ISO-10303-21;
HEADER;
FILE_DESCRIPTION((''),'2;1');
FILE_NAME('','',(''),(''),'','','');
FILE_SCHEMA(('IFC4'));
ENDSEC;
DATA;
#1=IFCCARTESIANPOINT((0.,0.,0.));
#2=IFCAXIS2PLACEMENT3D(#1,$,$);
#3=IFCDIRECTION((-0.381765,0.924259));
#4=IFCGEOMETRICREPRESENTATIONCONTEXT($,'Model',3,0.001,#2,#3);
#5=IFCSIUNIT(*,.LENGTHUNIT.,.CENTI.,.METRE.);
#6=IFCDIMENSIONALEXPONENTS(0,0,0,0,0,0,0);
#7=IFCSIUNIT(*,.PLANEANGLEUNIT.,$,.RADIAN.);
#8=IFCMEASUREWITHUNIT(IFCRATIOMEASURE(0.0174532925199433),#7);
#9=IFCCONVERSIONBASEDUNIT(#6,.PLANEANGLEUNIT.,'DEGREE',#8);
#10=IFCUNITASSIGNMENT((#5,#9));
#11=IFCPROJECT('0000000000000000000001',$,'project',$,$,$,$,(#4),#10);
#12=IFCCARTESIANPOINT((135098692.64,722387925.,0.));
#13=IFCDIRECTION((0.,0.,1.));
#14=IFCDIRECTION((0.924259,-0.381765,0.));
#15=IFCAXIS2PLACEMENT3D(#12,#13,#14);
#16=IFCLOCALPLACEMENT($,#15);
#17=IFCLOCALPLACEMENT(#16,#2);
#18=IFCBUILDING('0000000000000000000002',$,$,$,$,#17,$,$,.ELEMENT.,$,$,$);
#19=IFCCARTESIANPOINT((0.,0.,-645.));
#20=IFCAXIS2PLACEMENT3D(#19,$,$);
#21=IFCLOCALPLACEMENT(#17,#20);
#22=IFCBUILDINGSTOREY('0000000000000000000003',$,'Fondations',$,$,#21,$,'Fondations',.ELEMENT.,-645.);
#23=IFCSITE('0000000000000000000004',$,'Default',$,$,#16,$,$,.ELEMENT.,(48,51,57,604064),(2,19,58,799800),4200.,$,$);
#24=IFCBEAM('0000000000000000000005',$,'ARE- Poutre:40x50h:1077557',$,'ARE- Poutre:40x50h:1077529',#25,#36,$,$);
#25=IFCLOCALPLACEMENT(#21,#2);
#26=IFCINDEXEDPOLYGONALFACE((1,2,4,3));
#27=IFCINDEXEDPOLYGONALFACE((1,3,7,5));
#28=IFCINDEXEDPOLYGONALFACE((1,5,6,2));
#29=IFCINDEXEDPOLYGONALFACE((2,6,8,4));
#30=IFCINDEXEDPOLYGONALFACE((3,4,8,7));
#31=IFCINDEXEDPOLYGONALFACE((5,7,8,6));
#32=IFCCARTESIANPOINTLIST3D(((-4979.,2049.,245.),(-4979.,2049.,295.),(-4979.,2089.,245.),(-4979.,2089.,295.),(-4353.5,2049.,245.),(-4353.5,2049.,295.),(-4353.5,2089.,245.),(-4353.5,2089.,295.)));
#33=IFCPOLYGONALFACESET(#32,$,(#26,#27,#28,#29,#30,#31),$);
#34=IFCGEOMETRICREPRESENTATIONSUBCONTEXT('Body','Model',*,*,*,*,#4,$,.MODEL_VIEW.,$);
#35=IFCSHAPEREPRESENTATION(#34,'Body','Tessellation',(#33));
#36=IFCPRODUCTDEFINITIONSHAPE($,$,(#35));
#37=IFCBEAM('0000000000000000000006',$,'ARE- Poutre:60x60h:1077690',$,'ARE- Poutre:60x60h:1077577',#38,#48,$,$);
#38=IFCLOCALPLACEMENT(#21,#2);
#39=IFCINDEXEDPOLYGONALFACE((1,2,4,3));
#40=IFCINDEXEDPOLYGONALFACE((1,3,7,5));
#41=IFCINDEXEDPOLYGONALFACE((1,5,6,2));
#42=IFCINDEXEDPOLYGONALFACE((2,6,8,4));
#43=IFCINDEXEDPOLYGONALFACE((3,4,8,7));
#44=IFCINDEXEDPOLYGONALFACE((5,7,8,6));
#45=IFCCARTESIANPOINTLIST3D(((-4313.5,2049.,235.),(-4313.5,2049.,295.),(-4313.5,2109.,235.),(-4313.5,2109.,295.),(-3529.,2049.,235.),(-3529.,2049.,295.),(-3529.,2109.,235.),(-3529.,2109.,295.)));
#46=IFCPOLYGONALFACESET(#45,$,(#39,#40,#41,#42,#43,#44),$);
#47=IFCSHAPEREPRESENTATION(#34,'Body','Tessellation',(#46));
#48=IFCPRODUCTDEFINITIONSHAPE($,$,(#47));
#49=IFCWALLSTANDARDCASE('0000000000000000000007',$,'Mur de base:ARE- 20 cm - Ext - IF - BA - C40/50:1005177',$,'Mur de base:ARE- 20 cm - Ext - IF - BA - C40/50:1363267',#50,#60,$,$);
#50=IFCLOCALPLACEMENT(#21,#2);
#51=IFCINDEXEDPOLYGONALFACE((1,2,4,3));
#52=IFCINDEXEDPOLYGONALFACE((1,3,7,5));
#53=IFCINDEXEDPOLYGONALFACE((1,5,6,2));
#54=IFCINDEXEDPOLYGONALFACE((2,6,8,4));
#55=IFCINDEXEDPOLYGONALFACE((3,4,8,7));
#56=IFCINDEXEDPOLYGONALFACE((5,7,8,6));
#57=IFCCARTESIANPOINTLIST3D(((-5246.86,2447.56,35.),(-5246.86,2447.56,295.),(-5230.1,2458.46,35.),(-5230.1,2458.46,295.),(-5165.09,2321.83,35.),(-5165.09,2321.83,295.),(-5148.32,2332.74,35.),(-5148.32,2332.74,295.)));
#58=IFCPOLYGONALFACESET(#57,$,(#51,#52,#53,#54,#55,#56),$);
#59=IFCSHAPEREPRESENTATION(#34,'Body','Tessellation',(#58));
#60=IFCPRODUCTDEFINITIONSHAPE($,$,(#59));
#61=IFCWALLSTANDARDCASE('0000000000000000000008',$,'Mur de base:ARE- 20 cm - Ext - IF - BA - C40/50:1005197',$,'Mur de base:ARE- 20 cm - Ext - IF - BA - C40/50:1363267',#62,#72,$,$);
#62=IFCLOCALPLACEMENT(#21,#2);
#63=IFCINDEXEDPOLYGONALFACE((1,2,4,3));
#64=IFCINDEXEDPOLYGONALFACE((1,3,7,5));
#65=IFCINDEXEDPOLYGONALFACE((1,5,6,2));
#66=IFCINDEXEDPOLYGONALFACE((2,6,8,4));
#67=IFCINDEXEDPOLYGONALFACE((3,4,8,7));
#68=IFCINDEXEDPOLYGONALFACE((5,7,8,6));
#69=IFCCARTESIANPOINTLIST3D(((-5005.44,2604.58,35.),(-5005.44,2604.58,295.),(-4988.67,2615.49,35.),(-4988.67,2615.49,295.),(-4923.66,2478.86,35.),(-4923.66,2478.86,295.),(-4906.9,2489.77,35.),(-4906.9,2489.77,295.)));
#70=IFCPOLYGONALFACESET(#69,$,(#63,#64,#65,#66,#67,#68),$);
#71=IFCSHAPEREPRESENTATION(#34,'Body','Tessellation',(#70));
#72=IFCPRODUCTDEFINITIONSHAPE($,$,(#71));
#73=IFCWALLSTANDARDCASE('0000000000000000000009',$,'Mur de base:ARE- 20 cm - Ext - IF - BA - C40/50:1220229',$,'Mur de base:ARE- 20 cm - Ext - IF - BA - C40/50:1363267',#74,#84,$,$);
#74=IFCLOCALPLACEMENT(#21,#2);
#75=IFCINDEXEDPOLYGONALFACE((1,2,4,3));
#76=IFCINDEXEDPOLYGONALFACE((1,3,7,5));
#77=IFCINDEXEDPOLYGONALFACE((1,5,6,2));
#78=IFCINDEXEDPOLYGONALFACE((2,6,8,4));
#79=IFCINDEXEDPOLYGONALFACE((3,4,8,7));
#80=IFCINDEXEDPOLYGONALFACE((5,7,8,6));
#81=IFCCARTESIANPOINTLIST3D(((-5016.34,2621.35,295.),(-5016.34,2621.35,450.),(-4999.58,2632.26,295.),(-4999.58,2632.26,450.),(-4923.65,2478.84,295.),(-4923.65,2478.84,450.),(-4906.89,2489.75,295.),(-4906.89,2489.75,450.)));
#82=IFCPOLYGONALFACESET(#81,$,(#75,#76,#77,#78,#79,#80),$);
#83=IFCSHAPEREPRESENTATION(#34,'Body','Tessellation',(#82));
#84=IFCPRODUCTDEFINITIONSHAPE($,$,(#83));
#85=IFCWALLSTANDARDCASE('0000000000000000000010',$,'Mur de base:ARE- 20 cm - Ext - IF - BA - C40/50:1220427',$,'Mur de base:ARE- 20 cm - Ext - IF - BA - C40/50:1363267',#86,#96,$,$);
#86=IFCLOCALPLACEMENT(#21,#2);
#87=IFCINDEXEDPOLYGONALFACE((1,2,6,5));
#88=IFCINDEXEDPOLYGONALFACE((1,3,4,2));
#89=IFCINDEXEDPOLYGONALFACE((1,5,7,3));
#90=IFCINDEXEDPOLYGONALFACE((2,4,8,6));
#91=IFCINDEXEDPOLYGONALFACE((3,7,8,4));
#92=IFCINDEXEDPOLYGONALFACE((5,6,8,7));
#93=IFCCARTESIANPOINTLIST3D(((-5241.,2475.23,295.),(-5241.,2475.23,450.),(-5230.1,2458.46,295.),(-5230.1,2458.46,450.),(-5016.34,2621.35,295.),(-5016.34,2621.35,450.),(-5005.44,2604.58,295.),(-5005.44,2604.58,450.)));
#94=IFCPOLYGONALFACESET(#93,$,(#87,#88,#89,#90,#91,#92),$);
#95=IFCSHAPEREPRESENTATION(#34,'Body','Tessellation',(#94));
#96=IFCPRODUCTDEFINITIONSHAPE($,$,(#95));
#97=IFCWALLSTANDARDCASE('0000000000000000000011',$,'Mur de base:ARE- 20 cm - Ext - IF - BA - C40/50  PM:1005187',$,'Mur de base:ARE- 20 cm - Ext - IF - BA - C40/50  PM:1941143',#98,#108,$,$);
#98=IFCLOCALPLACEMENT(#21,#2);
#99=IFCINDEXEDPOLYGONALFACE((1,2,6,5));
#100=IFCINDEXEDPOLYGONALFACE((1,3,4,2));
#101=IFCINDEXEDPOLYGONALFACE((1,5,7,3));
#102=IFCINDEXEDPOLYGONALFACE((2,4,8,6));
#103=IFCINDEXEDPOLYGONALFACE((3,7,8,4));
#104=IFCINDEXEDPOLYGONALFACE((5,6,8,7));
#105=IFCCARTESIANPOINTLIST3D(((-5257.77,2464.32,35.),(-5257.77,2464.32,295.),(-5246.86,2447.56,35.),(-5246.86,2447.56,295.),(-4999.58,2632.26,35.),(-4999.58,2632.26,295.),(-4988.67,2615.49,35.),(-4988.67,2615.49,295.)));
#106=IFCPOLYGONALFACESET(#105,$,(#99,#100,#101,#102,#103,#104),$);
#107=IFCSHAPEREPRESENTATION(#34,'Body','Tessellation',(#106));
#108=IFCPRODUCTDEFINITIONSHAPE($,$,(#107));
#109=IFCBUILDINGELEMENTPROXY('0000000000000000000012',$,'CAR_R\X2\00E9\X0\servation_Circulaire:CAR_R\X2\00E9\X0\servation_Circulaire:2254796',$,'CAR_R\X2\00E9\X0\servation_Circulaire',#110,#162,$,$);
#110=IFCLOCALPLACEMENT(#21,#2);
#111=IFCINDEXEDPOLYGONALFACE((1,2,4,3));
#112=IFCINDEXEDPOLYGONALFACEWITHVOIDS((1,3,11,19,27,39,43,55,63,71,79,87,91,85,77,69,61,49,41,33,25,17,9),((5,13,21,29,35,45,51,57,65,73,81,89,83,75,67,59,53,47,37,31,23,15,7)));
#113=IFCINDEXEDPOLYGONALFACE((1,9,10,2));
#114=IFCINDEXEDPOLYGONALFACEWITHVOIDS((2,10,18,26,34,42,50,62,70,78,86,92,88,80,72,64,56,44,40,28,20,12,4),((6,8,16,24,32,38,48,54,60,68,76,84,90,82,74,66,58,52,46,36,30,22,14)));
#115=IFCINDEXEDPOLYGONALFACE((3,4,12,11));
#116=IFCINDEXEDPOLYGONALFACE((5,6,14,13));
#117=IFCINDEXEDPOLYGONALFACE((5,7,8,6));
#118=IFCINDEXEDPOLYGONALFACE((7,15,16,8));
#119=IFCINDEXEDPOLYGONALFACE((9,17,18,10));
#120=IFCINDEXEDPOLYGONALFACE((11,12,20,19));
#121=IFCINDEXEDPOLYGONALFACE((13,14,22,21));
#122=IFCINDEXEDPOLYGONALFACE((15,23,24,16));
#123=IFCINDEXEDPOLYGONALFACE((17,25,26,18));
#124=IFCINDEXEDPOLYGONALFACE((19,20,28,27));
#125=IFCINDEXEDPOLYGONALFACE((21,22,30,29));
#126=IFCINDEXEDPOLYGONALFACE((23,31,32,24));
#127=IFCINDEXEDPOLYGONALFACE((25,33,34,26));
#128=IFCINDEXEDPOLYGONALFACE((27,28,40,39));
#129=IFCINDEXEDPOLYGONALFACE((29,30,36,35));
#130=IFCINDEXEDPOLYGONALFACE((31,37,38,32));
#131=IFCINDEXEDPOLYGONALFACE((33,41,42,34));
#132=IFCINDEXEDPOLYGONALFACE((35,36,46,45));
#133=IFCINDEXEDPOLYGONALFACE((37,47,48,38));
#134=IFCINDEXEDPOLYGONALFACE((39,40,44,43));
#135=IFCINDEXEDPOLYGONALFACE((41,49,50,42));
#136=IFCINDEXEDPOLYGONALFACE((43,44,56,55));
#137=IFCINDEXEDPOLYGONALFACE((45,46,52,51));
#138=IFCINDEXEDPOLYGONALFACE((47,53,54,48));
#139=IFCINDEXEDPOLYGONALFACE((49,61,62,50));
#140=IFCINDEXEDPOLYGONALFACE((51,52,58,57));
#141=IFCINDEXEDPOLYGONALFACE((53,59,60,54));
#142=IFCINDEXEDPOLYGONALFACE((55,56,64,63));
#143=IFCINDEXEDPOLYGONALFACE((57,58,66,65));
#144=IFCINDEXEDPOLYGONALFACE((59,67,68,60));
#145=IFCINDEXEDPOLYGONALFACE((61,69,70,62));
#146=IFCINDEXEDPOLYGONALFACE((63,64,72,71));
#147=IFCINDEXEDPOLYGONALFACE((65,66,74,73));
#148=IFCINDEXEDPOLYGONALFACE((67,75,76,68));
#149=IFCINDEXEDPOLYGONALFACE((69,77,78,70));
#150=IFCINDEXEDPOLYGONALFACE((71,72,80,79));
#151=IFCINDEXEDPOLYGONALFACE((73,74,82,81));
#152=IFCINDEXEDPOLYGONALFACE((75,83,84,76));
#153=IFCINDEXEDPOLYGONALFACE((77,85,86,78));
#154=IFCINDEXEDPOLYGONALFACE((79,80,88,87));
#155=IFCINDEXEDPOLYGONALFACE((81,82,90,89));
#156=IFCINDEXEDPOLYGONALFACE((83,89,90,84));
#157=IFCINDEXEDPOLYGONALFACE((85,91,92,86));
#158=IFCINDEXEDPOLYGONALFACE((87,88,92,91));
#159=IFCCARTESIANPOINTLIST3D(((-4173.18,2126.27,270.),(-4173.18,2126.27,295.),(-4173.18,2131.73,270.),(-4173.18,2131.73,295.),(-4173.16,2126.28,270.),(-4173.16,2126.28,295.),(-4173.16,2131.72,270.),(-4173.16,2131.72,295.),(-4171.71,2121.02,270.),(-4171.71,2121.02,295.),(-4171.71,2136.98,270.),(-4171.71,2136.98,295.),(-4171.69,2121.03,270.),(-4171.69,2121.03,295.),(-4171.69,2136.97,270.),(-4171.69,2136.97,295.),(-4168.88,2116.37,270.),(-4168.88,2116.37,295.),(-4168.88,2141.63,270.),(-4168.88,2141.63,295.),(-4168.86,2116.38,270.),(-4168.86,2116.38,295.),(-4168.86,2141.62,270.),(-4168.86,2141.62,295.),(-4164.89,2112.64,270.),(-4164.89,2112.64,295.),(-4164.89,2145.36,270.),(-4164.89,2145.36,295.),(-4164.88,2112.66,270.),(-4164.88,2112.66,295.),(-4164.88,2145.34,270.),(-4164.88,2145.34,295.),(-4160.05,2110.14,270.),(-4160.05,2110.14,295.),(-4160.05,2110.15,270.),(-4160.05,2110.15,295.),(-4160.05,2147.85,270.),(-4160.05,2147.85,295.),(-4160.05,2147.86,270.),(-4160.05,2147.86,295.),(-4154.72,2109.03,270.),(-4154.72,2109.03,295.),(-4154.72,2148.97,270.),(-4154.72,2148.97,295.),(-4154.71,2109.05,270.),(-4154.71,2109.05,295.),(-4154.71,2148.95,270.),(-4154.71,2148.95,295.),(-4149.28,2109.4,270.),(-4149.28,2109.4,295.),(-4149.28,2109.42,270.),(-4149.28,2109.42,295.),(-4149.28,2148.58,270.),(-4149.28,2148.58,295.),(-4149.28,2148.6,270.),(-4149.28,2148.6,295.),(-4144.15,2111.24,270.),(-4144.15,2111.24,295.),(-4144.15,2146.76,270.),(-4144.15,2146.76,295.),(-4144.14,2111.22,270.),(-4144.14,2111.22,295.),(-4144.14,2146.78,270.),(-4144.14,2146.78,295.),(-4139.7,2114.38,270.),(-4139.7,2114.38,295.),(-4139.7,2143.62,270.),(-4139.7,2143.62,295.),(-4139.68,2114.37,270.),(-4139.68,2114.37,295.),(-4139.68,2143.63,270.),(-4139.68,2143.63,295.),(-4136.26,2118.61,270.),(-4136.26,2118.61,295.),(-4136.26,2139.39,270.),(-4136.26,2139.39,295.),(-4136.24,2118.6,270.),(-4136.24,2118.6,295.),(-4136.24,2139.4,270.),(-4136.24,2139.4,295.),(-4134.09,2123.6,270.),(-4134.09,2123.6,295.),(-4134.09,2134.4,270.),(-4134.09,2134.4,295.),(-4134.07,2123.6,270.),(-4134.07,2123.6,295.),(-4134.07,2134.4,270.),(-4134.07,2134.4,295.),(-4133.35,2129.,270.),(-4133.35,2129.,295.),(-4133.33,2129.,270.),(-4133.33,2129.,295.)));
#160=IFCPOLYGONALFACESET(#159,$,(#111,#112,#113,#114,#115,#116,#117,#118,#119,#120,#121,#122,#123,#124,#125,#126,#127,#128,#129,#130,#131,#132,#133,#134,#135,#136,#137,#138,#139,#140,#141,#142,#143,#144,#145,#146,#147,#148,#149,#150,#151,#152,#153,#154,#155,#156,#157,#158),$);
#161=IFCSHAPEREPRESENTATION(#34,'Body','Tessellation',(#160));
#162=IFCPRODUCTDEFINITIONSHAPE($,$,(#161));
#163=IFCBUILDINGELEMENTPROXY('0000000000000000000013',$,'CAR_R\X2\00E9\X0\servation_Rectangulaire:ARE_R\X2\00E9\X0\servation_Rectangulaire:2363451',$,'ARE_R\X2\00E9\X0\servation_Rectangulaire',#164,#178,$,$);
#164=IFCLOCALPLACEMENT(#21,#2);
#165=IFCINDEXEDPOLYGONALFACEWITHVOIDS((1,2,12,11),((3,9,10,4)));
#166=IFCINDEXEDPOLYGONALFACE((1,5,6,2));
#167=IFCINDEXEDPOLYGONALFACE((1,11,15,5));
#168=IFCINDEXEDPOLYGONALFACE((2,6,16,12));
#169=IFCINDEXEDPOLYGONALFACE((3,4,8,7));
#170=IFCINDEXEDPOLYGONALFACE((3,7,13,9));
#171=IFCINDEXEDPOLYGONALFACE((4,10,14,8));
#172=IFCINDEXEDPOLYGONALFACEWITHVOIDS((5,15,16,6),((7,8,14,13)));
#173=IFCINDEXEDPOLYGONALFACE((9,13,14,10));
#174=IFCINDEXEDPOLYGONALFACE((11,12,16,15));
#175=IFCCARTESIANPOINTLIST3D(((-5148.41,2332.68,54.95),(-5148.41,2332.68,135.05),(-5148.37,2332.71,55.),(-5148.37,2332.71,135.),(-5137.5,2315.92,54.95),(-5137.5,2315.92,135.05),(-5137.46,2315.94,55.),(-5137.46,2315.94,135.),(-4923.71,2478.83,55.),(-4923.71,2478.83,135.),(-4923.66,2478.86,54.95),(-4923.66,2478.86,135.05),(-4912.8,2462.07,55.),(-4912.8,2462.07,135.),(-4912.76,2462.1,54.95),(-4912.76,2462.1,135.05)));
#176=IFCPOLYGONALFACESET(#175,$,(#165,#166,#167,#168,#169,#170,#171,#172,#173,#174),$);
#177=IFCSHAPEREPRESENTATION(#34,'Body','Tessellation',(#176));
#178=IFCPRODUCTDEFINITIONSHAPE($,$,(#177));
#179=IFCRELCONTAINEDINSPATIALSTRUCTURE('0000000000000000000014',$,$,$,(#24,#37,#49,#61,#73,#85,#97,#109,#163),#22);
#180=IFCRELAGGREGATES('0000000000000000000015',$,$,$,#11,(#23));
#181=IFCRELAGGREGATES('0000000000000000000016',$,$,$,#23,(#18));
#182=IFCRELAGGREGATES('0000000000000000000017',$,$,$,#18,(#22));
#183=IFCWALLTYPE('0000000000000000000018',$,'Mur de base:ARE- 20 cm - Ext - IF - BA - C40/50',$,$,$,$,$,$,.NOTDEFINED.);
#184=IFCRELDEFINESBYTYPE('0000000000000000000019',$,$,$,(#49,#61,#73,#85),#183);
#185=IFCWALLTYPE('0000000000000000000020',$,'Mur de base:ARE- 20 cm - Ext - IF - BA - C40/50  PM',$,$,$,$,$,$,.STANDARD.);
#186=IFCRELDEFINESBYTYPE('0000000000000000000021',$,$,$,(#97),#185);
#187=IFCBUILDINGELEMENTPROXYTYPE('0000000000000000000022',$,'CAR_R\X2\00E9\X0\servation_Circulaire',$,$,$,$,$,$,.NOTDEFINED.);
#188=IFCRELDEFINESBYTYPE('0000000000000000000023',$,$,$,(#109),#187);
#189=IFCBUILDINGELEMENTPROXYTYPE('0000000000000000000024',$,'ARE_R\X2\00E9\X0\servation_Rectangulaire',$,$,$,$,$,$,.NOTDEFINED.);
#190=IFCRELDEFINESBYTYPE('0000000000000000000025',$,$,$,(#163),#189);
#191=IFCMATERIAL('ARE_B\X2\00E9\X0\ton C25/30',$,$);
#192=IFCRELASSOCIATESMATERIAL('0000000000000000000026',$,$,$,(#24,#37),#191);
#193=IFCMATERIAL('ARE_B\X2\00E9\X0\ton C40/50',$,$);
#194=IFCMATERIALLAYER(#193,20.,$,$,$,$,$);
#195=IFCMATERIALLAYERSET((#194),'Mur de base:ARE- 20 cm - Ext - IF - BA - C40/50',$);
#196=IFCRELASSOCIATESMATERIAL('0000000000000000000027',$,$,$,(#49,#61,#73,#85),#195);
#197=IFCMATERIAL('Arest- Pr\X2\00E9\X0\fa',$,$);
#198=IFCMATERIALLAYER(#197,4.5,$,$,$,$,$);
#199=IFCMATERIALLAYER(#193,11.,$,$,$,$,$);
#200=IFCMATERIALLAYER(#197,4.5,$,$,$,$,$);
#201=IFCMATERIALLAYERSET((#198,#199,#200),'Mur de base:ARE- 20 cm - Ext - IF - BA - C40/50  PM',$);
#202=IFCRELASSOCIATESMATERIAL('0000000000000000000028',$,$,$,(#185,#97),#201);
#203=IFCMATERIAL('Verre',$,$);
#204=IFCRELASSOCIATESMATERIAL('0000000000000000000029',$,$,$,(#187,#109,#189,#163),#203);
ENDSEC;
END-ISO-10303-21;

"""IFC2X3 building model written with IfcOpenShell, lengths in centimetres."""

from ifc_helpers import new_model, entity, si_unit, converted_unit, direction, frame, frame_2d, origin, place, context, subcontext, project, spatial, polyline, rectangle, hollow_circle, outline, extrude, source, transform, mapped, material, layer, layer_set, layer_usage, type_object, type_shapes, element, save


model = new_model("IFC2X3")

# Units and contexts
model_context = context("Model", 3, precision=0.001, world=origin(), true_north=direction((-0.381765, 0.924259)))
body_context = subcontext(model_context, "Body", "Model", "MODEL_VIEW")
ifc_project = project(units=[si_unit("LENGTHUNIT", "METRE", prefix="CENTI"), converted_unit("PLANEANGLEUNIT", "DEGREE", entity("IfcRatioMeasure", 0.0174532925199433), si_unit("PLANEANGLEUNIT", "RADIAN"), dimensions=[0, 0, 0, 0, 0, 0, 0])], contexts=[model_context])

# Site, building, storey
site_placement = place(None, frame((135098692.64, 722387925.0, 0.0), z_axis=(0.0, 0.0, 1.0), x_axis=(0.924259, -0.381765, 0.0)))
site = spatial("IfcSite", under=ifc_project, at=site_placement, Name="Default", CompositionType="ELEMENT", RefLatitude=(48, 51, 57, 604064), RefLongitude=(2, 19, 58, 799800), RefElevation=4200.0)
building_placement = place(site_placement, origin())
building = spatial("IfcBuilding", under=site, at=building_placement, CompositionType="ELEMENT")
storey_placement = place(building_placement, frame((0.0, 0.0, -645.0)))
storey = spatial("IfcBuildingStorey", under=building, at=storey_placement, Name="Fondations", LongName="Fondations", CompositionType="ELEMENT", Elevation=-645.0)

# Beams
ifc_material_1 = material(Name="ARE_Béton C25/30")
beam_1_placement = place(storey_placement, frame((-4979.0, 2069.0, 295.0)))
element("IfcBeam", 1, at=beam_1_placement, inside=storey, material=ifc_material_1, Name="ARE- Poutre:40x50h:1077557", ObjectType="ARE- Poutre:40x50h:1077529", context=body_context, shape_type="SweptSolid", body=[
    extrude(rectangle(XDim=50.0, YDim=40.0, at=frame_2d((0.0, 0.0), x_axis=(1.0, 0.0))), frame((0.0, 0.0, -25.0), z_axis=(1.0, 0.0, 0.0), x_axis=(0.0, 0.0, -1.0)), (0.0, 0.0, 1.0), 625.5),
])
beam_2_placement = place(storey_placement, frame((-4333.5, 2079.0, 295.0)))
element("IfcBeam", 2, at=beam_2_placement, inside=storey, material=ifc_material_1, Name="ARE- Poutre:60x60h:1077690", ObjectType="ARE- Poutre:60x60h:1077577", context=body_context, shape_type="SweptSolid", body=[
    extrude(rectangle(XDim=60.0, YDim=60.0, at=frame_2d((0.0, 0.0), x_axis=(1.0, 0.0))), frame((20.0, 0.0, -30.0), z_axis=(1.0, 0.0, 0.0), x_axis=(0.0, 0.0, -1.0)), (0.0, 0.0, 1.0), 784.5),
])

# Walls
ifc_material_2 = material(Name="ARE_Béton C40/50")
ifc_layer_1 = layer(ifc_material_2, 20.0)
ifc_layer_set_1 = layer_set([ifc_layer_1], Name="Mur de base:ARE- 20 cm - Ext - IF - BA - C40/50")
ifc_layer_usage_1 = layer_usage(ifc_layer_set_1, "AXIS2", "NEGATIVE", 10.0)
wall_type_1 = type_object("IfcWallType", Name="Mur de base:ARE- 20 cm - Ext - IF - BA - C40/50", PredefinedType="NOTDEFINED")
wall_1_placement = place(storey_placement, frame((-5238.48, 2453.01, 35.0), z_axis=(0.0, 0.0, 1.0), x_axis=(0.545236, -0.838282, 0.0)))
element("IfcWallStandardCase", 3, at=wall_1_placement, inside=storey, type_object=wall_type_1, material=ifc_layer_usage_1, Name="Mur de base:ARE- 20 cm - Ext - IF - BA - C40/50:1005177", ObjectType="Mur de base:ARE- 20 cm - Ext - IF - BA - C40/50:1363267", context=body_context, shape_type="SweptSolid", body=[
    extrude(rectangle(XDim=149.98, YDim=20.0, at=frame_2d((74.99, 0.0), x_axis=(-1.0, 0.0))), origin(), (0.0, 0.0, 1.0), 260.0),
])
ifc_layer_usage_2 = layer_usage(ifc_layer_set_1, "AXIS2", "NEGATIVE", 10.0)
wall_2_placement = place(storey_placement, frame((-4997.05, 2610.04, 35.0), z_axis=(0.0, 0.0, 1.0), x_axis=(0.545236, -0.838282, 0.0)))
element("IfcWallStandardCase", 4, at=wall_2_placement, inside=storey, type_object=wall_type_1, material=ifc_layer_usage_2, Name="Mur de base:ARE- 20 cm - Ext - IF - BA - C40/50:1005197", ObjectType="Mur de base:ARE- 20 cm - Ext - IF - BA - C40/50:1363267", context=body_context, shape_type="SweptSolid", body=[
    extrude(rectangle(XDim=149.98, YDim=20.0, at=frame_2d((74.99, 0.0), x_axis=(-1.0, 0.0))), origin(), (0.0, 0.0, 1.0), 260.0),
])
ifc_layer_usage_3 = layer_usage(ifc_layer_set_1, "AXIS2", "NEGATIVE", 10.0)
wall_3_placement = place(storey_placement, frame((-5007.96, 2626.8, 295.0), z_axis=(0.0, 0.0, 1.0), x_axis=(0.545236, -0.838282, 0.0)))
element("IfcWallStandardCase", 5, at=wall_3_placement, inside=storey, type_object=wall_type_1, material=ifc_layer_usage_3, Name="Mur de base:ARE- 20 cm - Ext - IF - BA - C40/50:1220229", ObjectType="Mur de base:ARE- 20 cm - Ext - IF - BA - C40/50:1363267", context=body_context, shape_type="SweptSolid", body=[
    extrude(rectangle(XDim=170.0, YDim=20.0, at=frame_2d((85.0, 0.0), x_axis=(-1.0, 0.0))), origin(), (0.0, 0.0, 1.0), 155.0),
])
ifc_layer_usage_4 = layer_usage(ifc_layer_set_1, "AXIS2", "NEGATIVE", 10.0)
wall_4_placement = place(storey_placement, frame((-5235.55, 2466.84, 295.0), z_axis=(0.0, 0.0, 1.0), x_axis=(0.838282, 0.545236, 0.0)))
element("IfcWallStandardCase", 6, at=wall_4_placement, inside=storey, type_object=wall_type_1, material=ifc_layer_usage_4, Name="Mur de base:ARE- 20 cm - Ext - IF - BA - C40/50:1220427", ObjectType="Mur de base:ARE- 20 cm - Ext - IF - BA - C40/50:1363267", context=body_context, shape_type="SweptSolid", body=[
    extrude(rectangle(XDim=268.0, YDim=20.0, at=frame_2d((134.0, 0.0), x_axis=(-1.0, 0.0))), origin(), (0.0, 0.0, 1.0), 155.0),
])
ifc_material_3 = material(Name="Arest- Préfa")
ifc_layer_2 = layer(ifc_material_3, 4.5)
ifc_layer_3 = layer(ifc_material_2, 11.0)
ifc_layer_4 = layer(ifc_material_3, 4.5)
ifc_layer_set_2 = layer_set([ifc_layer_2, ifc_layer_3, ifc_layer_4], Name="Mur de base:ARE- 20 cm - Ext - IF - BA - C40/50  PM")
ifc_layer_usage_5 = layer_usage(ifc_layer_set_2, "AXIS2", "NEGATIVE", 10.0)
wall_type_2 = type_object("IfcWallType", Name="Mur de base:ARE- 20 cm - Ext - IF - BA - C40/50  PM", PredefinedType="STANDARD", material=ifc_layer_set_2)
wall_5_placement = place(storey_placement, frame((-4994.12, 2623.87, 35.0), z_axis=(0.0, 0.0, 1.0), x_axis=(-0.838282, -0.545236, 0.0)))
element("IfcWallStandardCase", 7, at=wall_5_placement, inside=storey, type_object=wall_type_2, material=ifc_layer_usage_5, Name="Mur de base:ARE- 20 cm - Ext - IF - BA - C40/50  PM:1005187", ObjectType="Mur de base:ARE- 20 cm - Ext - IF - BA - C40/50  PM:1941143", context=body_context, shape_type="SweptSolid", body=[
    extrude(rectangle(XDim=308.0, YDim=20.0, at=frame_2d((154.0, 0.0), x_axis=(-1.0, 0.0))), origin(), (0.0, 0.0, 1.0), 260.0),
])

# Building element proxies
ifc_material_4 = material(Name="Verre")
building_element_proxy_type_1 = type_object("IfcBuildingElementProxyType", Name="CAR_Réservation_Circulaire", PredefinedType="NOTDEFINED", material=ifc_material_4)
shared_shape_1 = source(origin(), body_context, "Body", "SweptSolid", [
    extrude(hollow_circle(Radius=20.02, WallThickness=0.02, at=frame_2d((0.0, 0.0), x_axis=(1.0, 0.0))), frame((0.0, 0.0, -25.0)), (0.0, 0.0, 1.0), 25.0),
])
type_shapes(building_element_proxy_type_1, [shared_shape_1])
proxy_1_placement = place(storey_placement, frame((-4153.35, 2129.0, 295.0)))
element("IfcBuildingElementProxy", 8, at=proxy_1_placement, inside=storey, type_object=building_element_proxy_type_1, material=ifc_material_4, Name="CAR_Réservation_Circulaire:CAR_Réservation_Circulaire:2254796", ObjectType="CAR_Réservation_Circulaire", context=body_context, shape_type="MappedRepresentation", body=[
    mapped(shared_shape_1, transform((0.0, 0.0, 0.0), scale=1.0)),
])
building_element_proxy_type_2 = type_object("IfcBuildingElementProxyType", Name="ARE_Réservation_Rectangulaire", PredefinedType="NOTDEFINED", material=ifc_material_4)
shared_shape_2 = source(origin(), body_context, "Body", "SweptSolid", [
    extrude(outline(polyline([(-134.05, -40.05), (134.05, -40.05), (134.05, 40.05), (-134.05, 40.05), (-134.05, -40.05)]), holes=[polyline([(134.0, -40.0), (-134.0, -40.0), (-134.0, 40.0), (134.0, 40.0), (134.0, -40.0)])]), frame((0.0, 0.0, -20.0), z_axis=(0.0, 0.0, 1.0), x_axis=(-1.0, 0.0, 0.0)), (0.0, 0.0, 1.0), 20.0),
])
type_shapes(building_element_proxy_type_2, [shared_shape_2])
proxy_2_placement = place(storey_placement, frame((-5036.04, 2405.77, 95.0), z_axis=(-0.545236, 0.838282, 0.0), x_axis=(-0.838282, -0.545236, 0.0)))
element("IfcBuildingElementProxy", 9, at=proxy_2_placement, inside=storey, type_object=building_element_proxy_type_2, material=ifc_material_4, Name="CAR_Réservation_Rectangulaire:ARE_Réservation_Rectangulaire:2363451", ObjectType="ARE_Réservation_Rectangulaire", context=body_context, shape_type="MappedRepresentation", body=[
    mapped(shared_shape_2, transform((0.0, 0.0, 0.0), scale=1.0)),
])

save(model, "model.ifc")
